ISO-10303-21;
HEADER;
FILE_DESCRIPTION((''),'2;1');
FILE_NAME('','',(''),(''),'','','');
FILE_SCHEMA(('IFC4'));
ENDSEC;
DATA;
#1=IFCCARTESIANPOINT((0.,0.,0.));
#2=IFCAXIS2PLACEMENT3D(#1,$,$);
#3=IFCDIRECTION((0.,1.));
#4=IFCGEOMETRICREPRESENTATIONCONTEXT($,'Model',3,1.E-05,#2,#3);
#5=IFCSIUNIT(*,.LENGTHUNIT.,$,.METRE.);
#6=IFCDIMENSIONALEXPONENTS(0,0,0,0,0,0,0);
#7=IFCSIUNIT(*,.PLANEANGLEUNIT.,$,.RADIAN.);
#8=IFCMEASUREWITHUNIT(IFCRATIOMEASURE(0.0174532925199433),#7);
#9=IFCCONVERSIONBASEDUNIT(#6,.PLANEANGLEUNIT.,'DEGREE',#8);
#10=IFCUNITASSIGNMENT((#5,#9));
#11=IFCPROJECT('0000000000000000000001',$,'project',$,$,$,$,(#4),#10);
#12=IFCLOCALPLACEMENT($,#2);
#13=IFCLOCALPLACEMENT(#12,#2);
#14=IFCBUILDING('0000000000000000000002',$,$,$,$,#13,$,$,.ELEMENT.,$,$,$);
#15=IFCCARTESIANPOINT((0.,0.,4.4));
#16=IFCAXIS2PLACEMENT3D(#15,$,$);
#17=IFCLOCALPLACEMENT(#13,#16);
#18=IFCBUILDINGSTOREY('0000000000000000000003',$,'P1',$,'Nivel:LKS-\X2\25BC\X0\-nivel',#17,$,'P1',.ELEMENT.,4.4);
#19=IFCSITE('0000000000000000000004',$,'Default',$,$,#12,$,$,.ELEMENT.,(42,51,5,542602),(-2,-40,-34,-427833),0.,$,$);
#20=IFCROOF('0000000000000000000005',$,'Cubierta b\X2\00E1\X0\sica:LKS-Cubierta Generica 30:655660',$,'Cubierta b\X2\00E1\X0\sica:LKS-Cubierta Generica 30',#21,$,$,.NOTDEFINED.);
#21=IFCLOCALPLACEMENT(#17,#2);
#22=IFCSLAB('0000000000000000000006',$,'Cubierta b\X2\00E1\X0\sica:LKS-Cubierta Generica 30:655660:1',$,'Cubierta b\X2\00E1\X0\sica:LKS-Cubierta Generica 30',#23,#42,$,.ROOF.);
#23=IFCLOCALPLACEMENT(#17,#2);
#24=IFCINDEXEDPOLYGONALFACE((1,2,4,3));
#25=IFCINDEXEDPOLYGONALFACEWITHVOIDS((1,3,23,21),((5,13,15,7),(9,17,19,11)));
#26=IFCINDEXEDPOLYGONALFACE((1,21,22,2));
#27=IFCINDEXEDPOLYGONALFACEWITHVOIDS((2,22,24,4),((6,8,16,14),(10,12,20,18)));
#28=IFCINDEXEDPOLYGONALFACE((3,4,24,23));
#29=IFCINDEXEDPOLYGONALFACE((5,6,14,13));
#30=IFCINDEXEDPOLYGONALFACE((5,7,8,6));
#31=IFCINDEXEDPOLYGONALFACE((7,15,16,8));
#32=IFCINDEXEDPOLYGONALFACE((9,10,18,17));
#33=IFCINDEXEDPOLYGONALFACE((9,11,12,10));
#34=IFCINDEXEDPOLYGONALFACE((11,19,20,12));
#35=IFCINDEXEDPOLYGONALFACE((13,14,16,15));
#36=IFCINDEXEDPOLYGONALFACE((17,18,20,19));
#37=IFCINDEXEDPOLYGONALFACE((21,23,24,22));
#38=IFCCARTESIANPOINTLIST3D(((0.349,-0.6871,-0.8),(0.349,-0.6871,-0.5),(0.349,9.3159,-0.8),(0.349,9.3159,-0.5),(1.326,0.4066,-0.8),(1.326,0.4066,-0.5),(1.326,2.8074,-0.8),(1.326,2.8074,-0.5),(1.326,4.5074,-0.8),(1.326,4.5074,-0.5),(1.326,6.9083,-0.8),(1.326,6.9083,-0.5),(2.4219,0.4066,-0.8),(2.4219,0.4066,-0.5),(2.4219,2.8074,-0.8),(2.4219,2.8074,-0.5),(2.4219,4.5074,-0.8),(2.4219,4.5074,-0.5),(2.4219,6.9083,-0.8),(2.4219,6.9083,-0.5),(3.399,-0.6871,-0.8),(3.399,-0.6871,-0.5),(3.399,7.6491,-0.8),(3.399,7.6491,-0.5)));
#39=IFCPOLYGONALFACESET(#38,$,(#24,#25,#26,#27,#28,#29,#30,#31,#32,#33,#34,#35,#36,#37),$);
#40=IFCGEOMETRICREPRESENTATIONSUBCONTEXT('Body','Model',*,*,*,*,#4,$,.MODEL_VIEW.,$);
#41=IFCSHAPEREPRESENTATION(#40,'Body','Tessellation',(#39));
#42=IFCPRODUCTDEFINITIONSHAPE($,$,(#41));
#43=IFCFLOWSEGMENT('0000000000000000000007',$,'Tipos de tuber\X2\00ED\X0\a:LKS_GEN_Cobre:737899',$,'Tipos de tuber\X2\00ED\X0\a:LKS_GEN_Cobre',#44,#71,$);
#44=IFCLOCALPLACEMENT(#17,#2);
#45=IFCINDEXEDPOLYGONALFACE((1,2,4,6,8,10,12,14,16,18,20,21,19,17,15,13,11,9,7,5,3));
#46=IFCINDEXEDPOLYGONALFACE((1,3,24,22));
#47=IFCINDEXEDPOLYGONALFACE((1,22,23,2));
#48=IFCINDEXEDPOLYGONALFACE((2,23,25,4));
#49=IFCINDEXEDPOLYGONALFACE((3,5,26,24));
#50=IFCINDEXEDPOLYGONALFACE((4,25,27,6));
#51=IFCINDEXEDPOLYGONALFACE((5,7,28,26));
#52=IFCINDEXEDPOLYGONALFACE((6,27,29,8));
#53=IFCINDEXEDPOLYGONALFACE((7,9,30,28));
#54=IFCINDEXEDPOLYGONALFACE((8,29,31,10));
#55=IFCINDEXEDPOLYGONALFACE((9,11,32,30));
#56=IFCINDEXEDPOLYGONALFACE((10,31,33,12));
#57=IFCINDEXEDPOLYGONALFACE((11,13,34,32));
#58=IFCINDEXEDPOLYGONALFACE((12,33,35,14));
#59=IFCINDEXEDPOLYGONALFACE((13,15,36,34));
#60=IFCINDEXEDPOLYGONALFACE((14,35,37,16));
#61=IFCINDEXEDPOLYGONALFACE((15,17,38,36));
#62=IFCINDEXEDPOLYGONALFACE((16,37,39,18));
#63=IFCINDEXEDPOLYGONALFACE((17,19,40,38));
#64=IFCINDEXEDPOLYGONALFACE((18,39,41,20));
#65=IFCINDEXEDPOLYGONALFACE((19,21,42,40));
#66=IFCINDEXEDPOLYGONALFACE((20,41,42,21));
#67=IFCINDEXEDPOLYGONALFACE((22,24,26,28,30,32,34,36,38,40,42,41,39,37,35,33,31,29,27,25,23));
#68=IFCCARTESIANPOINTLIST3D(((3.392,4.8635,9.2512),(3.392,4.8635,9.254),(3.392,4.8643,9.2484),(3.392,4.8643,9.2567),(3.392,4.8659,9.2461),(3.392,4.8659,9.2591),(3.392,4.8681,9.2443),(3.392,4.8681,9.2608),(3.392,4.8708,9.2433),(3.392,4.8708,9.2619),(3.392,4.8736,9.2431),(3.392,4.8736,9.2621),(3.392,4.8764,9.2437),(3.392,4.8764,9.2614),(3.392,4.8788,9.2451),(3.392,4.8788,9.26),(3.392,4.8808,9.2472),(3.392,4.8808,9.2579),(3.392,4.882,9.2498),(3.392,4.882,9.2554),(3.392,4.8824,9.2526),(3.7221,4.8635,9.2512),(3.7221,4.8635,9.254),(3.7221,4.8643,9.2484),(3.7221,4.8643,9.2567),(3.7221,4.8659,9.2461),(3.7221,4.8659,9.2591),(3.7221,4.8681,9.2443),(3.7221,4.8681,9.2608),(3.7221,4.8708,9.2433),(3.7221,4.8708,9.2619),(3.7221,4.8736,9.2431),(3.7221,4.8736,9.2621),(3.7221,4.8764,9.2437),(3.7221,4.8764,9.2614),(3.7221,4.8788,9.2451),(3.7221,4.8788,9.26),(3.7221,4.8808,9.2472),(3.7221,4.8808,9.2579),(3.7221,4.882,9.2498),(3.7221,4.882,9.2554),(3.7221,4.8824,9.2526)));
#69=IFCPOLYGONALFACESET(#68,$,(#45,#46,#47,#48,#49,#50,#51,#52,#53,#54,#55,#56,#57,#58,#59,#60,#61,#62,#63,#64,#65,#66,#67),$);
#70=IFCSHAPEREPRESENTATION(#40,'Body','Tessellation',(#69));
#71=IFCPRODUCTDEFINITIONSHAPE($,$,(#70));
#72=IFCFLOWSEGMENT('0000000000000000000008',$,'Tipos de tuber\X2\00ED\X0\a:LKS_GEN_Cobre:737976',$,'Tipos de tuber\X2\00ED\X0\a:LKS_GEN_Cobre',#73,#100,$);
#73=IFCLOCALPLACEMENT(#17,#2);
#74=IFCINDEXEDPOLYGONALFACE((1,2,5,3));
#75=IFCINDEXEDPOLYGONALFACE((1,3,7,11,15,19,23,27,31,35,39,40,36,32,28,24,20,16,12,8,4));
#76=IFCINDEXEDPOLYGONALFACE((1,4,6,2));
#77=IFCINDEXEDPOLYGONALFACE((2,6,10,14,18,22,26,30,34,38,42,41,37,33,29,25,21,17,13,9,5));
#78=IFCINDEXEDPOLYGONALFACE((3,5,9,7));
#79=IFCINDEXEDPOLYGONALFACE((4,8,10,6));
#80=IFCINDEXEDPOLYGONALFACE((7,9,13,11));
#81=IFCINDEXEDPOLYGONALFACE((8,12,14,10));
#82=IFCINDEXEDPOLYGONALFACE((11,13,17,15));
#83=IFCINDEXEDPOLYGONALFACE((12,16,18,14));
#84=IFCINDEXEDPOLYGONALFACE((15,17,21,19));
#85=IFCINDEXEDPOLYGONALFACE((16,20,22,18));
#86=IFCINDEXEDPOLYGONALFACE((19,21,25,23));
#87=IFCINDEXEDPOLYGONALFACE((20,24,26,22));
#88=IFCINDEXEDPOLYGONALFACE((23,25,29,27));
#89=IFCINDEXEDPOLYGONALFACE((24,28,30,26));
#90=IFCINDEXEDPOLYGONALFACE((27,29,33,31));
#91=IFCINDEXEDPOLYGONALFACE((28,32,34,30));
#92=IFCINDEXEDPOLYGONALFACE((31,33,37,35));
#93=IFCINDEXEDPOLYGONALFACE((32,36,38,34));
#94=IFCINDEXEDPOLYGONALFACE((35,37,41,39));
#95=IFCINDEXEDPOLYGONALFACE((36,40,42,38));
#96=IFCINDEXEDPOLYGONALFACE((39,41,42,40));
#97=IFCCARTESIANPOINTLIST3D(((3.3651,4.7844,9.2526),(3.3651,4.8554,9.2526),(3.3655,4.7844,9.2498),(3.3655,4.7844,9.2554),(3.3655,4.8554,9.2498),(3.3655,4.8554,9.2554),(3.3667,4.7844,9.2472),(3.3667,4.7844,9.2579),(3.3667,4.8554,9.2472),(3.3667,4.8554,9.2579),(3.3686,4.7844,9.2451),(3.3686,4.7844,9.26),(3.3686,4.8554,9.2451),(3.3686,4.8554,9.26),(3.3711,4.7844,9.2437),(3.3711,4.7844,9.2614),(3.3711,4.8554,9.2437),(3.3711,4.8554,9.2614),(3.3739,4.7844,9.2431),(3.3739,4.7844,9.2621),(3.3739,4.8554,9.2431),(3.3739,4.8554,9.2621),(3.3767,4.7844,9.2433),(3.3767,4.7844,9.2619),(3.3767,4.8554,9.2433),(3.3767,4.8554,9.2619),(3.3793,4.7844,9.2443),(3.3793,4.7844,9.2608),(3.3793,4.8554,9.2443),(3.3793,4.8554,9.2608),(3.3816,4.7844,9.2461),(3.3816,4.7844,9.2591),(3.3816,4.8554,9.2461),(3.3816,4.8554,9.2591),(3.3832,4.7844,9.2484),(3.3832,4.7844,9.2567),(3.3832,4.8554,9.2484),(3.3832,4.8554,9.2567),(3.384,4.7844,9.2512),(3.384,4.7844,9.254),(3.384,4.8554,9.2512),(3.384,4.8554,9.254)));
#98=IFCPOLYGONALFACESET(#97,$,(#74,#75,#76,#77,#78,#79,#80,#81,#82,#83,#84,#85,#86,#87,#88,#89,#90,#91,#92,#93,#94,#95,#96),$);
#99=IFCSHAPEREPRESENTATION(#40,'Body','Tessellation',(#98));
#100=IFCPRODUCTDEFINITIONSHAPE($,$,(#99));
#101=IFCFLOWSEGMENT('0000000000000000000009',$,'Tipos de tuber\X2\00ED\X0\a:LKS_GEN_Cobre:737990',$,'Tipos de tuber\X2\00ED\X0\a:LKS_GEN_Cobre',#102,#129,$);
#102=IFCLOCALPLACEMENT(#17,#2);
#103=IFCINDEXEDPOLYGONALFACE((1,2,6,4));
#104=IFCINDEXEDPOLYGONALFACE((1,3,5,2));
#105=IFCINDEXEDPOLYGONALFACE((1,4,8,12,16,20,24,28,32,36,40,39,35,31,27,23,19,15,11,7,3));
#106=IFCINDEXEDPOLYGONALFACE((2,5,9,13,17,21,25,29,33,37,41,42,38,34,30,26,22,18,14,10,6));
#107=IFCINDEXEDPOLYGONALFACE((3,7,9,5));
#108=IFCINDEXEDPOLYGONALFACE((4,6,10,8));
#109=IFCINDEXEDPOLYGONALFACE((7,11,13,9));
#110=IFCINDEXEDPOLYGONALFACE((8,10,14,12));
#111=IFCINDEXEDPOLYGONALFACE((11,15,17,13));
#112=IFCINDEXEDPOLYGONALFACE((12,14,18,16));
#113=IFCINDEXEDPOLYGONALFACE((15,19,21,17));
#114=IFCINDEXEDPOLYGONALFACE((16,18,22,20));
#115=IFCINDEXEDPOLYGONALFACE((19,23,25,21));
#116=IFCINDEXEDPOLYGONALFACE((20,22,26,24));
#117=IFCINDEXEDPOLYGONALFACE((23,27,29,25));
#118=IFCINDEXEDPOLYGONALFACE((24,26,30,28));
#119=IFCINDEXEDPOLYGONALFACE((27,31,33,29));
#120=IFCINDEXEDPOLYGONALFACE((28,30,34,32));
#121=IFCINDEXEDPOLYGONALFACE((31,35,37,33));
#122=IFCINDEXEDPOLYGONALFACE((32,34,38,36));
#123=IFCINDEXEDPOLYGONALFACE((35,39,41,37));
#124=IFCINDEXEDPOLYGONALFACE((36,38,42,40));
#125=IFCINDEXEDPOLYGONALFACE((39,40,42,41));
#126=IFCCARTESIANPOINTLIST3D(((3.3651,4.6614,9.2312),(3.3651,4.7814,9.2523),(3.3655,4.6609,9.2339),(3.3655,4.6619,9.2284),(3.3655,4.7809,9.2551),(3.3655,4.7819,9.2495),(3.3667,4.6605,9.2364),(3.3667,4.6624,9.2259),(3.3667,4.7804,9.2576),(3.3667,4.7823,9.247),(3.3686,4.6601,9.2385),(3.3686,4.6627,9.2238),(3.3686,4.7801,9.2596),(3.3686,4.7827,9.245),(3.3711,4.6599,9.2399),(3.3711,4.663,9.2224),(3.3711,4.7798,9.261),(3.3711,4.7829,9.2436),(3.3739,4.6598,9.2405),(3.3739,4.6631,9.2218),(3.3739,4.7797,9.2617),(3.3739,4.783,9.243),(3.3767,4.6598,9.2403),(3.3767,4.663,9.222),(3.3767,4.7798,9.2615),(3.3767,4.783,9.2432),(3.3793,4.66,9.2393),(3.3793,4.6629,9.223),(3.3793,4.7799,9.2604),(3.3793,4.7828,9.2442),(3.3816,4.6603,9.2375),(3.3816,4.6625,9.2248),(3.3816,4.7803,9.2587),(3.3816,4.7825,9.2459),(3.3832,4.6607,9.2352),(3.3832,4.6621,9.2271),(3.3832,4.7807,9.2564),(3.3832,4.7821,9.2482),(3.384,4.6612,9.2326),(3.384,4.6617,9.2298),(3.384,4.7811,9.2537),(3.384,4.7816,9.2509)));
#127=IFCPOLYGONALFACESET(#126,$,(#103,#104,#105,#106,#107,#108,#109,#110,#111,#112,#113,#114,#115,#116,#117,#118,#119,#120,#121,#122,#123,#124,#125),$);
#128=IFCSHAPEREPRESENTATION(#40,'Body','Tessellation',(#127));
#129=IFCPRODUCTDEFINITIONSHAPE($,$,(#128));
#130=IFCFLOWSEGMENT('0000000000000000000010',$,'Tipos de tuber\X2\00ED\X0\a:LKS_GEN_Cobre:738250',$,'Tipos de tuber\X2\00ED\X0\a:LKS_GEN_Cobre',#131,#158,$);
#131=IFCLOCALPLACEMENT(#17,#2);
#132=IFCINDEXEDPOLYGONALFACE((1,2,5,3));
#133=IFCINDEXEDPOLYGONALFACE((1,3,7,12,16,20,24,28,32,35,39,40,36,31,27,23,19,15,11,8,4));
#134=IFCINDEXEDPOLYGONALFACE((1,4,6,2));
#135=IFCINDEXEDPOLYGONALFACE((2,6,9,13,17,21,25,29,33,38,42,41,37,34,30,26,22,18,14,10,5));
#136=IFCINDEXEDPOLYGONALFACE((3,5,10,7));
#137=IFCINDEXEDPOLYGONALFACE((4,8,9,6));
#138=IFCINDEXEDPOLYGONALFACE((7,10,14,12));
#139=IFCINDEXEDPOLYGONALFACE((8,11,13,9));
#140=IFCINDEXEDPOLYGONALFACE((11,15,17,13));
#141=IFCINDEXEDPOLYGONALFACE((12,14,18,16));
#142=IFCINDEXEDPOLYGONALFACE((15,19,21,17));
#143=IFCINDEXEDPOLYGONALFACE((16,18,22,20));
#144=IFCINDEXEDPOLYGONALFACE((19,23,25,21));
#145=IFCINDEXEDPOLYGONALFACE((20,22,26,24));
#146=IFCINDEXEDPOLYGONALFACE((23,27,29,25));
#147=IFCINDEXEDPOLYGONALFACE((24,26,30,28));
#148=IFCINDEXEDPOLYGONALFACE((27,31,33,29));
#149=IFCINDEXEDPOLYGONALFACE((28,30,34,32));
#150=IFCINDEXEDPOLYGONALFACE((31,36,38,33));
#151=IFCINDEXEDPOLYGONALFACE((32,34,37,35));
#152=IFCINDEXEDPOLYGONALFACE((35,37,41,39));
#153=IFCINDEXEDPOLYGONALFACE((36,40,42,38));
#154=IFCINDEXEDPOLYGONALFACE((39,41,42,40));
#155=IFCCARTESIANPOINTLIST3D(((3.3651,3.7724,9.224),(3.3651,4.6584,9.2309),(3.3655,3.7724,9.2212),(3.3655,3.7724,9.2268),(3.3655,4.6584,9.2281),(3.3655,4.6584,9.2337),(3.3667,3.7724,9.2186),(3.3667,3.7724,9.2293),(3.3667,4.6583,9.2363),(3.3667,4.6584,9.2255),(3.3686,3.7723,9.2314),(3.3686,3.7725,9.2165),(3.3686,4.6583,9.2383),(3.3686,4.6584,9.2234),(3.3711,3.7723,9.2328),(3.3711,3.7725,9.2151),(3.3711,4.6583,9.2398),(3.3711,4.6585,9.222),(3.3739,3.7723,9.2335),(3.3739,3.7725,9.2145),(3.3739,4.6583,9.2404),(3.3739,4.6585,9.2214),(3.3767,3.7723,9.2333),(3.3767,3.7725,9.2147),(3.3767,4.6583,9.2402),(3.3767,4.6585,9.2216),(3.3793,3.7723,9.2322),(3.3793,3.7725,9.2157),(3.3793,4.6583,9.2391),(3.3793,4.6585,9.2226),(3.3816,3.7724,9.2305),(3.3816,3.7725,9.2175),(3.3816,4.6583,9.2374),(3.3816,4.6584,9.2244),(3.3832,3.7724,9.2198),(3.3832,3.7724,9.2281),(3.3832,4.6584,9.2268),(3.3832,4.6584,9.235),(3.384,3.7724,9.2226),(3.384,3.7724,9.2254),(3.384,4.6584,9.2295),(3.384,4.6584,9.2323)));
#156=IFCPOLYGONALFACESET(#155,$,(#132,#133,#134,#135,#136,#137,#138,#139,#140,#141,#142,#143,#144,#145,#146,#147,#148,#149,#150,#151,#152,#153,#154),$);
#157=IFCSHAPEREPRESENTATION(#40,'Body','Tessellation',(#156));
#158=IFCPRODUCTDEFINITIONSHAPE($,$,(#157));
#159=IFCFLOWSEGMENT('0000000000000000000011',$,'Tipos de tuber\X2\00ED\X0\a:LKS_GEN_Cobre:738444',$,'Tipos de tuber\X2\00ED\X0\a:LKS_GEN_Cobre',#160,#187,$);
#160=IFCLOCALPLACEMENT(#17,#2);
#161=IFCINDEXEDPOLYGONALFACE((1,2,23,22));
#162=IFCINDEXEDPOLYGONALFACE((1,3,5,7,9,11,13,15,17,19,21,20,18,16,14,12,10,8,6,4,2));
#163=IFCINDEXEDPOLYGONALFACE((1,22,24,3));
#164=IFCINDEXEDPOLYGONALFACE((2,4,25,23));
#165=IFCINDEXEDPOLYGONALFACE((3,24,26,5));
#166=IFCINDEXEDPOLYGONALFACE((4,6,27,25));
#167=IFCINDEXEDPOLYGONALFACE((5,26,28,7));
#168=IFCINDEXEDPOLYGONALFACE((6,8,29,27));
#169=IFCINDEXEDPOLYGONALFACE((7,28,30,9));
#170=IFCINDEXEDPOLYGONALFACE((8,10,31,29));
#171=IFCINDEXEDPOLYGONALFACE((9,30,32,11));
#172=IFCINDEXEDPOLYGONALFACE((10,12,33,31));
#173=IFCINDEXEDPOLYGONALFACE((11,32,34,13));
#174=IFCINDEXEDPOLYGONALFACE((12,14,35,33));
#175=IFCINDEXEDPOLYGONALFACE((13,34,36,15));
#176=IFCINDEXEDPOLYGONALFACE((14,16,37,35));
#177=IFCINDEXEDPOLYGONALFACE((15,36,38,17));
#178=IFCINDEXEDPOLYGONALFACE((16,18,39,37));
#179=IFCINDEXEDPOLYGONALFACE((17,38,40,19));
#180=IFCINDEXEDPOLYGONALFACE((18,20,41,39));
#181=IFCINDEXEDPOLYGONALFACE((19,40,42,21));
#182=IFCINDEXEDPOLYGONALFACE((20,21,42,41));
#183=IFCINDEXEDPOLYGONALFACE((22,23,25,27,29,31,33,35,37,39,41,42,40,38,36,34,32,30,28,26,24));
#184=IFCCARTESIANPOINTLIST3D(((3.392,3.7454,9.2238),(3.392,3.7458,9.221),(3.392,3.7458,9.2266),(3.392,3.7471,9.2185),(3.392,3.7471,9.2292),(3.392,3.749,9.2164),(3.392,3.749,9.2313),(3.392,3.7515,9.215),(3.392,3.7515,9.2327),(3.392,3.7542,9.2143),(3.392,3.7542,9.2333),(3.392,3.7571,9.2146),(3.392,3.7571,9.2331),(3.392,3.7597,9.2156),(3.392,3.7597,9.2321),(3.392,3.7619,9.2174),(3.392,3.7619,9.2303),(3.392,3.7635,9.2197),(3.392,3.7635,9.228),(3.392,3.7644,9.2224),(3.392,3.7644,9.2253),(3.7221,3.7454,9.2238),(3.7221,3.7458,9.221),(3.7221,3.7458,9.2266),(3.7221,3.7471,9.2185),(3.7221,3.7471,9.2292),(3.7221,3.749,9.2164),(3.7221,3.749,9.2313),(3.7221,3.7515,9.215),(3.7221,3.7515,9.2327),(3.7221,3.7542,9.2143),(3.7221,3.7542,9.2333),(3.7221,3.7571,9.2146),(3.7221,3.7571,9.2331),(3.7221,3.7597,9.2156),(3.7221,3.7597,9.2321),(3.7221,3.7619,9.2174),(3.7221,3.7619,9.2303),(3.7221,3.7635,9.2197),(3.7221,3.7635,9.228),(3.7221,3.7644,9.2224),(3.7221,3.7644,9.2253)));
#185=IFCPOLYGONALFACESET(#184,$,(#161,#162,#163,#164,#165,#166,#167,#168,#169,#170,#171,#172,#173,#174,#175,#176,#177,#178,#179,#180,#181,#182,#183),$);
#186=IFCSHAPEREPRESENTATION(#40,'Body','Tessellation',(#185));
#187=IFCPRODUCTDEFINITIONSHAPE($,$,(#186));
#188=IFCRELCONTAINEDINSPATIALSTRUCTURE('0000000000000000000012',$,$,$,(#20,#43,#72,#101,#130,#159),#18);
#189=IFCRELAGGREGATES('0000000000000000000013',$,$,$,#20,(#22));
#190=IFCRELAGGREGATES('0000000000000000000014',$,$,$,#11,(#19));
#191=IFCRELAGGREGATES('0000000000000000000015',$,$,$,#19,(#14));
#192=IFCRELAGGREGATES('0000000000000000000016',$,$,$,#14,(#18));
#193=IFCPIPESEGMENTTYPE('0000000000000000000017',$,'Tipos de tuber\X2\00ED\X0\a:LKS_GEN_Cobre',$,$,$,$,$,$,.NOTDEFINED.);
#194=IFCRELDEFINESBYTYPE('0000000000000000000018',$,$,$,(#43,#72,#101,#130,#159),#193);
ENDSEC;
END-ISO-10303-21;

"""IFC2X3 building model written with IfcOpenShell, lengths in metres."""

from ifc_helpers import new_model, entity, si_unit, converted_unit, direction, frame, frame_2d, origin, origin_2d_with_axis, place, context, subcontext, project, spatial, polyline, rectangle, circle, outline, extrude, type_object, element, aggregate, save


model = new_model("IFC2X3")

# Units and contexts
model_context = context("Model", 3, precision=1e-05, world=origin(), true_north=direction((0.0, 1.0)))
body_context = subcontext(model_context, "Body", "Model", "MODEL_VIEW")
ifc_project = project(units=[si_unit("LENGTHUNIT", "METRE"), converted_unit("PLANEANGLEUNIT", "DEGREE", entity("IfcRatioMeasure", 0.0174532925199433), si_unit("PLANEANGLEUNIT", "RADIAN"), dimensions=[0, 0, 0, 0, 0, 0, 0])], contexts=[model_context])

# Site, building, storey
site_placement = place(None, origin())
site = spatial("IfcSite", under=ifc_project, at=site_placement, Name="Default", CompositionType="ELEMENT", RefLatitude=(42, 51, 5, 542602), RefLongitude=(-2, -40, -34, -427833), RefElevation=0.0)
building_placement = place(site_placement, origin())
building = spatial("IfcBuilding", under=site, at=building_placement, CompositionType="ELEMENT")
storey_placement = place(building_placement, frame((0.0, 0.0, 4.4)))
storey = spatial("IfcBuildingStorey", under=building, at=storey_placement, Name="P1", ObjectType="Nivel:LKS-▼-nivel", LongName="P1", CompositionType="ELEMENT", Elevation=4.4)

# Roof, slab, openings
roof_placement = place(storey_placement, origin())
roof = element("IfcRoof", 1, at=roof_placement, inside=storey, Name="Cubierta básica:LKS-Cubierta Generica 30:655660", ObjectType="Cubierta básica:LKS-Cubierta Generica 30", ShapeType="NOTDEFINED")
slab_1_placement = place(storey_placement, origin())
slab_1 = element("IfcSlab", 2, at=slab_1_placement, Name="Cubierta básica:LKS-Cubierta Generica 30:655660:1", ObjectType="Cubierta básica:LKS-Cubierta Generica 30", PredefinedType="ROOF", context=body_context, shape_type="SweptSolid", body=[
    extrude(outline(polyline([(-5.4182, -1.525), (4.5848, -1.525), (4.5848, 1.525), (-3.7514, 1.525), (-5.4182, -1.525)])), frame((1.874, 3.8977, -0.8), z_axis=(0.0, 0.0, 1.0), x_axis=(0.0, -1.0, 0.0)), (0.0, 0.0, 1.0), 0.3),
])
opening_1_placement = place(storey_placement, origin())
element("IfcOpeningElement", 3, at=opening_1_placement, cuts=slab_1, ObjectType="Opening", context=body_context, shape_type="SweptSolid", body=[
    extrude(rectangle(XDim=2.4009, YDim=1.0959, at=frame_2d((0.0, 0.0), x_axis=(1.0, 0.0))), frame((1.874, 5.7079, -0.8), z_axis=(0.0, 0.0, 1.0), x_axis=(0.0, 1.0, 0.0)), (0.0, 0.0, 1.0), 0.3),
])
opening_2_placement = place(storey_placement, origin())
element("IfcOpeningElement", 4, at=opening_2_placement, cuts=slab_1, ObjectType="Opening", context=body_context, shape_type="SweptSolid", body=[
    extrude(rectangle(XDim=2.4008, YDim=1.0959, at=frame_2d((0.0, 0.0), x_axis=(1.0, 0.0))), frame((1.874, 1.607, -0.8), z_axis=(0.0, 0.0, 1.0), x_axis=(0.0, 1.0, 0.0)), (0.0, 0.0, 1.0), 0.3),
])
aggregate(roof, [slab_1])

# Flow segments
pipe_segment_type_1 = type_object("IfcPipeSegmentType", Name="Tipos de tubería:LKS_GEN_Cobre", PredefinedType="NOTDEFINED")
flow_segment_1_placement = place(storey_placement, origin())
element("IfcFlowSegment", 5, at=flow_segment_1_placement, inside=storey, type_object=pipe_segment_type_1, Name="Tipos de tubería:LKS_GEN_Cobre:737899", ObjectType="Tipos de tubería:LKS_GEN_Cobre", context=body_context, shape_type="SweptSolid", body=[
    extrude(circle(Radius=0.0095, at=frame_2d((0.0, 0.0), x_axis=(1.0, 0.0))), frame((3.392, 4.8729, 9.2526), z_axis=(1.0, 0.0, 0.0), x_axis=(0.0, 1.0, 0.0)), (0.0, 0.0, 1.0), 0.3301),
])
flow_segment_2_placement = place(storey_placement, origin())
element("IfcFlowSegment", 6, at=flow_segment_2_placement, inside=storey, type_object=pipe_segment_type_1, Name="Tipos de tubería:LKS_GEN_Cobre:737976", ObjectType="Tipos de tubería:LKS_GEN_Cobre", context=body_context, shape_type="SweptSolid", body=[
    extrude(circle(Radius=0.0095, at=frame_2d((0.0, 0.0), x_axis=(1.0, 0.0))), frame((3.3746, 4.7844, 9.2526), z_axis=(0.0, 1.0, 0.0), x_axis=(-1.0, 0.0, 0.0)), (0.0, 0.0, 1.0), 0.071),
])
flow_segment_3_placement = place(storey_placement, origin())
element("IfcFlowSegment", 7, at=flow_segment_3_placement, inside=storey, type_object=pipe_segment_type_1, Name="Tipos de tubería:LKS_GEN_Cobre:737990", ObjectType="Tipos de tubería:LKS_GEN_Cobre", context=body_context, shape_type="SweptSolid", body=[
    extrude(circle(Radius=0.0095, at=origin_2d_with_axis()), frame((3.3746, 4.6614, 9.2312), z_axis=(0.0, 0.984808, 0.173648), x_axis=(-1.0, 0.0, 0.0)), (0.0, 0.0, 1.0), 0.1218),
])
flow_segment_4_placement = place(storey_placement, origin())
element("IfcFlowSegment", 8, at=flow_segment_4_placement, inside=storey, type_object=pipe_segment_type_1, Name="Tipos de tubería:LKS_GEN_Cobre:738250", ObjectType="Tipos de tubería:LKS_GEN_Cobre", context=body_context, shape_type="SweptSolid", body=[
    extrude(circle(Radius=0.0095, at=origin_2d_with_axis()), frame((3.3746, 3.7724, 9.224), z_axis=(0.0, 0.99997, 0.007806), x_axis=(-1.0, 0.0, 0.0)), (0.0, 0.0, 1.0), 0.886),
])
flow_segment_5_placement = place(storey_placement, origin())
element("IfcFlowSegment", 9, at=flow_segment_5_placement, inside=storey, type_object=pipe_segment_type_1, Name="Tipos de tubería:LKS_GEN_Cobre:738444", ObjectType="Tipos de tubería:LKS_GEN_Cobre", context=body_context, shape_type="SweptSolid", body=[
    extrude(circle(Radius=0.0095, at=origin_2d_with_axis()), frame((3.392, 3.7549, 9.2238), z_axis=(1.0, 0.0, 0.0), x_axis=(0.0, -1.0, 0.0)), (0.0, 0.0, 1.0), 0.3301),
])

save(model, "model.ifc")
